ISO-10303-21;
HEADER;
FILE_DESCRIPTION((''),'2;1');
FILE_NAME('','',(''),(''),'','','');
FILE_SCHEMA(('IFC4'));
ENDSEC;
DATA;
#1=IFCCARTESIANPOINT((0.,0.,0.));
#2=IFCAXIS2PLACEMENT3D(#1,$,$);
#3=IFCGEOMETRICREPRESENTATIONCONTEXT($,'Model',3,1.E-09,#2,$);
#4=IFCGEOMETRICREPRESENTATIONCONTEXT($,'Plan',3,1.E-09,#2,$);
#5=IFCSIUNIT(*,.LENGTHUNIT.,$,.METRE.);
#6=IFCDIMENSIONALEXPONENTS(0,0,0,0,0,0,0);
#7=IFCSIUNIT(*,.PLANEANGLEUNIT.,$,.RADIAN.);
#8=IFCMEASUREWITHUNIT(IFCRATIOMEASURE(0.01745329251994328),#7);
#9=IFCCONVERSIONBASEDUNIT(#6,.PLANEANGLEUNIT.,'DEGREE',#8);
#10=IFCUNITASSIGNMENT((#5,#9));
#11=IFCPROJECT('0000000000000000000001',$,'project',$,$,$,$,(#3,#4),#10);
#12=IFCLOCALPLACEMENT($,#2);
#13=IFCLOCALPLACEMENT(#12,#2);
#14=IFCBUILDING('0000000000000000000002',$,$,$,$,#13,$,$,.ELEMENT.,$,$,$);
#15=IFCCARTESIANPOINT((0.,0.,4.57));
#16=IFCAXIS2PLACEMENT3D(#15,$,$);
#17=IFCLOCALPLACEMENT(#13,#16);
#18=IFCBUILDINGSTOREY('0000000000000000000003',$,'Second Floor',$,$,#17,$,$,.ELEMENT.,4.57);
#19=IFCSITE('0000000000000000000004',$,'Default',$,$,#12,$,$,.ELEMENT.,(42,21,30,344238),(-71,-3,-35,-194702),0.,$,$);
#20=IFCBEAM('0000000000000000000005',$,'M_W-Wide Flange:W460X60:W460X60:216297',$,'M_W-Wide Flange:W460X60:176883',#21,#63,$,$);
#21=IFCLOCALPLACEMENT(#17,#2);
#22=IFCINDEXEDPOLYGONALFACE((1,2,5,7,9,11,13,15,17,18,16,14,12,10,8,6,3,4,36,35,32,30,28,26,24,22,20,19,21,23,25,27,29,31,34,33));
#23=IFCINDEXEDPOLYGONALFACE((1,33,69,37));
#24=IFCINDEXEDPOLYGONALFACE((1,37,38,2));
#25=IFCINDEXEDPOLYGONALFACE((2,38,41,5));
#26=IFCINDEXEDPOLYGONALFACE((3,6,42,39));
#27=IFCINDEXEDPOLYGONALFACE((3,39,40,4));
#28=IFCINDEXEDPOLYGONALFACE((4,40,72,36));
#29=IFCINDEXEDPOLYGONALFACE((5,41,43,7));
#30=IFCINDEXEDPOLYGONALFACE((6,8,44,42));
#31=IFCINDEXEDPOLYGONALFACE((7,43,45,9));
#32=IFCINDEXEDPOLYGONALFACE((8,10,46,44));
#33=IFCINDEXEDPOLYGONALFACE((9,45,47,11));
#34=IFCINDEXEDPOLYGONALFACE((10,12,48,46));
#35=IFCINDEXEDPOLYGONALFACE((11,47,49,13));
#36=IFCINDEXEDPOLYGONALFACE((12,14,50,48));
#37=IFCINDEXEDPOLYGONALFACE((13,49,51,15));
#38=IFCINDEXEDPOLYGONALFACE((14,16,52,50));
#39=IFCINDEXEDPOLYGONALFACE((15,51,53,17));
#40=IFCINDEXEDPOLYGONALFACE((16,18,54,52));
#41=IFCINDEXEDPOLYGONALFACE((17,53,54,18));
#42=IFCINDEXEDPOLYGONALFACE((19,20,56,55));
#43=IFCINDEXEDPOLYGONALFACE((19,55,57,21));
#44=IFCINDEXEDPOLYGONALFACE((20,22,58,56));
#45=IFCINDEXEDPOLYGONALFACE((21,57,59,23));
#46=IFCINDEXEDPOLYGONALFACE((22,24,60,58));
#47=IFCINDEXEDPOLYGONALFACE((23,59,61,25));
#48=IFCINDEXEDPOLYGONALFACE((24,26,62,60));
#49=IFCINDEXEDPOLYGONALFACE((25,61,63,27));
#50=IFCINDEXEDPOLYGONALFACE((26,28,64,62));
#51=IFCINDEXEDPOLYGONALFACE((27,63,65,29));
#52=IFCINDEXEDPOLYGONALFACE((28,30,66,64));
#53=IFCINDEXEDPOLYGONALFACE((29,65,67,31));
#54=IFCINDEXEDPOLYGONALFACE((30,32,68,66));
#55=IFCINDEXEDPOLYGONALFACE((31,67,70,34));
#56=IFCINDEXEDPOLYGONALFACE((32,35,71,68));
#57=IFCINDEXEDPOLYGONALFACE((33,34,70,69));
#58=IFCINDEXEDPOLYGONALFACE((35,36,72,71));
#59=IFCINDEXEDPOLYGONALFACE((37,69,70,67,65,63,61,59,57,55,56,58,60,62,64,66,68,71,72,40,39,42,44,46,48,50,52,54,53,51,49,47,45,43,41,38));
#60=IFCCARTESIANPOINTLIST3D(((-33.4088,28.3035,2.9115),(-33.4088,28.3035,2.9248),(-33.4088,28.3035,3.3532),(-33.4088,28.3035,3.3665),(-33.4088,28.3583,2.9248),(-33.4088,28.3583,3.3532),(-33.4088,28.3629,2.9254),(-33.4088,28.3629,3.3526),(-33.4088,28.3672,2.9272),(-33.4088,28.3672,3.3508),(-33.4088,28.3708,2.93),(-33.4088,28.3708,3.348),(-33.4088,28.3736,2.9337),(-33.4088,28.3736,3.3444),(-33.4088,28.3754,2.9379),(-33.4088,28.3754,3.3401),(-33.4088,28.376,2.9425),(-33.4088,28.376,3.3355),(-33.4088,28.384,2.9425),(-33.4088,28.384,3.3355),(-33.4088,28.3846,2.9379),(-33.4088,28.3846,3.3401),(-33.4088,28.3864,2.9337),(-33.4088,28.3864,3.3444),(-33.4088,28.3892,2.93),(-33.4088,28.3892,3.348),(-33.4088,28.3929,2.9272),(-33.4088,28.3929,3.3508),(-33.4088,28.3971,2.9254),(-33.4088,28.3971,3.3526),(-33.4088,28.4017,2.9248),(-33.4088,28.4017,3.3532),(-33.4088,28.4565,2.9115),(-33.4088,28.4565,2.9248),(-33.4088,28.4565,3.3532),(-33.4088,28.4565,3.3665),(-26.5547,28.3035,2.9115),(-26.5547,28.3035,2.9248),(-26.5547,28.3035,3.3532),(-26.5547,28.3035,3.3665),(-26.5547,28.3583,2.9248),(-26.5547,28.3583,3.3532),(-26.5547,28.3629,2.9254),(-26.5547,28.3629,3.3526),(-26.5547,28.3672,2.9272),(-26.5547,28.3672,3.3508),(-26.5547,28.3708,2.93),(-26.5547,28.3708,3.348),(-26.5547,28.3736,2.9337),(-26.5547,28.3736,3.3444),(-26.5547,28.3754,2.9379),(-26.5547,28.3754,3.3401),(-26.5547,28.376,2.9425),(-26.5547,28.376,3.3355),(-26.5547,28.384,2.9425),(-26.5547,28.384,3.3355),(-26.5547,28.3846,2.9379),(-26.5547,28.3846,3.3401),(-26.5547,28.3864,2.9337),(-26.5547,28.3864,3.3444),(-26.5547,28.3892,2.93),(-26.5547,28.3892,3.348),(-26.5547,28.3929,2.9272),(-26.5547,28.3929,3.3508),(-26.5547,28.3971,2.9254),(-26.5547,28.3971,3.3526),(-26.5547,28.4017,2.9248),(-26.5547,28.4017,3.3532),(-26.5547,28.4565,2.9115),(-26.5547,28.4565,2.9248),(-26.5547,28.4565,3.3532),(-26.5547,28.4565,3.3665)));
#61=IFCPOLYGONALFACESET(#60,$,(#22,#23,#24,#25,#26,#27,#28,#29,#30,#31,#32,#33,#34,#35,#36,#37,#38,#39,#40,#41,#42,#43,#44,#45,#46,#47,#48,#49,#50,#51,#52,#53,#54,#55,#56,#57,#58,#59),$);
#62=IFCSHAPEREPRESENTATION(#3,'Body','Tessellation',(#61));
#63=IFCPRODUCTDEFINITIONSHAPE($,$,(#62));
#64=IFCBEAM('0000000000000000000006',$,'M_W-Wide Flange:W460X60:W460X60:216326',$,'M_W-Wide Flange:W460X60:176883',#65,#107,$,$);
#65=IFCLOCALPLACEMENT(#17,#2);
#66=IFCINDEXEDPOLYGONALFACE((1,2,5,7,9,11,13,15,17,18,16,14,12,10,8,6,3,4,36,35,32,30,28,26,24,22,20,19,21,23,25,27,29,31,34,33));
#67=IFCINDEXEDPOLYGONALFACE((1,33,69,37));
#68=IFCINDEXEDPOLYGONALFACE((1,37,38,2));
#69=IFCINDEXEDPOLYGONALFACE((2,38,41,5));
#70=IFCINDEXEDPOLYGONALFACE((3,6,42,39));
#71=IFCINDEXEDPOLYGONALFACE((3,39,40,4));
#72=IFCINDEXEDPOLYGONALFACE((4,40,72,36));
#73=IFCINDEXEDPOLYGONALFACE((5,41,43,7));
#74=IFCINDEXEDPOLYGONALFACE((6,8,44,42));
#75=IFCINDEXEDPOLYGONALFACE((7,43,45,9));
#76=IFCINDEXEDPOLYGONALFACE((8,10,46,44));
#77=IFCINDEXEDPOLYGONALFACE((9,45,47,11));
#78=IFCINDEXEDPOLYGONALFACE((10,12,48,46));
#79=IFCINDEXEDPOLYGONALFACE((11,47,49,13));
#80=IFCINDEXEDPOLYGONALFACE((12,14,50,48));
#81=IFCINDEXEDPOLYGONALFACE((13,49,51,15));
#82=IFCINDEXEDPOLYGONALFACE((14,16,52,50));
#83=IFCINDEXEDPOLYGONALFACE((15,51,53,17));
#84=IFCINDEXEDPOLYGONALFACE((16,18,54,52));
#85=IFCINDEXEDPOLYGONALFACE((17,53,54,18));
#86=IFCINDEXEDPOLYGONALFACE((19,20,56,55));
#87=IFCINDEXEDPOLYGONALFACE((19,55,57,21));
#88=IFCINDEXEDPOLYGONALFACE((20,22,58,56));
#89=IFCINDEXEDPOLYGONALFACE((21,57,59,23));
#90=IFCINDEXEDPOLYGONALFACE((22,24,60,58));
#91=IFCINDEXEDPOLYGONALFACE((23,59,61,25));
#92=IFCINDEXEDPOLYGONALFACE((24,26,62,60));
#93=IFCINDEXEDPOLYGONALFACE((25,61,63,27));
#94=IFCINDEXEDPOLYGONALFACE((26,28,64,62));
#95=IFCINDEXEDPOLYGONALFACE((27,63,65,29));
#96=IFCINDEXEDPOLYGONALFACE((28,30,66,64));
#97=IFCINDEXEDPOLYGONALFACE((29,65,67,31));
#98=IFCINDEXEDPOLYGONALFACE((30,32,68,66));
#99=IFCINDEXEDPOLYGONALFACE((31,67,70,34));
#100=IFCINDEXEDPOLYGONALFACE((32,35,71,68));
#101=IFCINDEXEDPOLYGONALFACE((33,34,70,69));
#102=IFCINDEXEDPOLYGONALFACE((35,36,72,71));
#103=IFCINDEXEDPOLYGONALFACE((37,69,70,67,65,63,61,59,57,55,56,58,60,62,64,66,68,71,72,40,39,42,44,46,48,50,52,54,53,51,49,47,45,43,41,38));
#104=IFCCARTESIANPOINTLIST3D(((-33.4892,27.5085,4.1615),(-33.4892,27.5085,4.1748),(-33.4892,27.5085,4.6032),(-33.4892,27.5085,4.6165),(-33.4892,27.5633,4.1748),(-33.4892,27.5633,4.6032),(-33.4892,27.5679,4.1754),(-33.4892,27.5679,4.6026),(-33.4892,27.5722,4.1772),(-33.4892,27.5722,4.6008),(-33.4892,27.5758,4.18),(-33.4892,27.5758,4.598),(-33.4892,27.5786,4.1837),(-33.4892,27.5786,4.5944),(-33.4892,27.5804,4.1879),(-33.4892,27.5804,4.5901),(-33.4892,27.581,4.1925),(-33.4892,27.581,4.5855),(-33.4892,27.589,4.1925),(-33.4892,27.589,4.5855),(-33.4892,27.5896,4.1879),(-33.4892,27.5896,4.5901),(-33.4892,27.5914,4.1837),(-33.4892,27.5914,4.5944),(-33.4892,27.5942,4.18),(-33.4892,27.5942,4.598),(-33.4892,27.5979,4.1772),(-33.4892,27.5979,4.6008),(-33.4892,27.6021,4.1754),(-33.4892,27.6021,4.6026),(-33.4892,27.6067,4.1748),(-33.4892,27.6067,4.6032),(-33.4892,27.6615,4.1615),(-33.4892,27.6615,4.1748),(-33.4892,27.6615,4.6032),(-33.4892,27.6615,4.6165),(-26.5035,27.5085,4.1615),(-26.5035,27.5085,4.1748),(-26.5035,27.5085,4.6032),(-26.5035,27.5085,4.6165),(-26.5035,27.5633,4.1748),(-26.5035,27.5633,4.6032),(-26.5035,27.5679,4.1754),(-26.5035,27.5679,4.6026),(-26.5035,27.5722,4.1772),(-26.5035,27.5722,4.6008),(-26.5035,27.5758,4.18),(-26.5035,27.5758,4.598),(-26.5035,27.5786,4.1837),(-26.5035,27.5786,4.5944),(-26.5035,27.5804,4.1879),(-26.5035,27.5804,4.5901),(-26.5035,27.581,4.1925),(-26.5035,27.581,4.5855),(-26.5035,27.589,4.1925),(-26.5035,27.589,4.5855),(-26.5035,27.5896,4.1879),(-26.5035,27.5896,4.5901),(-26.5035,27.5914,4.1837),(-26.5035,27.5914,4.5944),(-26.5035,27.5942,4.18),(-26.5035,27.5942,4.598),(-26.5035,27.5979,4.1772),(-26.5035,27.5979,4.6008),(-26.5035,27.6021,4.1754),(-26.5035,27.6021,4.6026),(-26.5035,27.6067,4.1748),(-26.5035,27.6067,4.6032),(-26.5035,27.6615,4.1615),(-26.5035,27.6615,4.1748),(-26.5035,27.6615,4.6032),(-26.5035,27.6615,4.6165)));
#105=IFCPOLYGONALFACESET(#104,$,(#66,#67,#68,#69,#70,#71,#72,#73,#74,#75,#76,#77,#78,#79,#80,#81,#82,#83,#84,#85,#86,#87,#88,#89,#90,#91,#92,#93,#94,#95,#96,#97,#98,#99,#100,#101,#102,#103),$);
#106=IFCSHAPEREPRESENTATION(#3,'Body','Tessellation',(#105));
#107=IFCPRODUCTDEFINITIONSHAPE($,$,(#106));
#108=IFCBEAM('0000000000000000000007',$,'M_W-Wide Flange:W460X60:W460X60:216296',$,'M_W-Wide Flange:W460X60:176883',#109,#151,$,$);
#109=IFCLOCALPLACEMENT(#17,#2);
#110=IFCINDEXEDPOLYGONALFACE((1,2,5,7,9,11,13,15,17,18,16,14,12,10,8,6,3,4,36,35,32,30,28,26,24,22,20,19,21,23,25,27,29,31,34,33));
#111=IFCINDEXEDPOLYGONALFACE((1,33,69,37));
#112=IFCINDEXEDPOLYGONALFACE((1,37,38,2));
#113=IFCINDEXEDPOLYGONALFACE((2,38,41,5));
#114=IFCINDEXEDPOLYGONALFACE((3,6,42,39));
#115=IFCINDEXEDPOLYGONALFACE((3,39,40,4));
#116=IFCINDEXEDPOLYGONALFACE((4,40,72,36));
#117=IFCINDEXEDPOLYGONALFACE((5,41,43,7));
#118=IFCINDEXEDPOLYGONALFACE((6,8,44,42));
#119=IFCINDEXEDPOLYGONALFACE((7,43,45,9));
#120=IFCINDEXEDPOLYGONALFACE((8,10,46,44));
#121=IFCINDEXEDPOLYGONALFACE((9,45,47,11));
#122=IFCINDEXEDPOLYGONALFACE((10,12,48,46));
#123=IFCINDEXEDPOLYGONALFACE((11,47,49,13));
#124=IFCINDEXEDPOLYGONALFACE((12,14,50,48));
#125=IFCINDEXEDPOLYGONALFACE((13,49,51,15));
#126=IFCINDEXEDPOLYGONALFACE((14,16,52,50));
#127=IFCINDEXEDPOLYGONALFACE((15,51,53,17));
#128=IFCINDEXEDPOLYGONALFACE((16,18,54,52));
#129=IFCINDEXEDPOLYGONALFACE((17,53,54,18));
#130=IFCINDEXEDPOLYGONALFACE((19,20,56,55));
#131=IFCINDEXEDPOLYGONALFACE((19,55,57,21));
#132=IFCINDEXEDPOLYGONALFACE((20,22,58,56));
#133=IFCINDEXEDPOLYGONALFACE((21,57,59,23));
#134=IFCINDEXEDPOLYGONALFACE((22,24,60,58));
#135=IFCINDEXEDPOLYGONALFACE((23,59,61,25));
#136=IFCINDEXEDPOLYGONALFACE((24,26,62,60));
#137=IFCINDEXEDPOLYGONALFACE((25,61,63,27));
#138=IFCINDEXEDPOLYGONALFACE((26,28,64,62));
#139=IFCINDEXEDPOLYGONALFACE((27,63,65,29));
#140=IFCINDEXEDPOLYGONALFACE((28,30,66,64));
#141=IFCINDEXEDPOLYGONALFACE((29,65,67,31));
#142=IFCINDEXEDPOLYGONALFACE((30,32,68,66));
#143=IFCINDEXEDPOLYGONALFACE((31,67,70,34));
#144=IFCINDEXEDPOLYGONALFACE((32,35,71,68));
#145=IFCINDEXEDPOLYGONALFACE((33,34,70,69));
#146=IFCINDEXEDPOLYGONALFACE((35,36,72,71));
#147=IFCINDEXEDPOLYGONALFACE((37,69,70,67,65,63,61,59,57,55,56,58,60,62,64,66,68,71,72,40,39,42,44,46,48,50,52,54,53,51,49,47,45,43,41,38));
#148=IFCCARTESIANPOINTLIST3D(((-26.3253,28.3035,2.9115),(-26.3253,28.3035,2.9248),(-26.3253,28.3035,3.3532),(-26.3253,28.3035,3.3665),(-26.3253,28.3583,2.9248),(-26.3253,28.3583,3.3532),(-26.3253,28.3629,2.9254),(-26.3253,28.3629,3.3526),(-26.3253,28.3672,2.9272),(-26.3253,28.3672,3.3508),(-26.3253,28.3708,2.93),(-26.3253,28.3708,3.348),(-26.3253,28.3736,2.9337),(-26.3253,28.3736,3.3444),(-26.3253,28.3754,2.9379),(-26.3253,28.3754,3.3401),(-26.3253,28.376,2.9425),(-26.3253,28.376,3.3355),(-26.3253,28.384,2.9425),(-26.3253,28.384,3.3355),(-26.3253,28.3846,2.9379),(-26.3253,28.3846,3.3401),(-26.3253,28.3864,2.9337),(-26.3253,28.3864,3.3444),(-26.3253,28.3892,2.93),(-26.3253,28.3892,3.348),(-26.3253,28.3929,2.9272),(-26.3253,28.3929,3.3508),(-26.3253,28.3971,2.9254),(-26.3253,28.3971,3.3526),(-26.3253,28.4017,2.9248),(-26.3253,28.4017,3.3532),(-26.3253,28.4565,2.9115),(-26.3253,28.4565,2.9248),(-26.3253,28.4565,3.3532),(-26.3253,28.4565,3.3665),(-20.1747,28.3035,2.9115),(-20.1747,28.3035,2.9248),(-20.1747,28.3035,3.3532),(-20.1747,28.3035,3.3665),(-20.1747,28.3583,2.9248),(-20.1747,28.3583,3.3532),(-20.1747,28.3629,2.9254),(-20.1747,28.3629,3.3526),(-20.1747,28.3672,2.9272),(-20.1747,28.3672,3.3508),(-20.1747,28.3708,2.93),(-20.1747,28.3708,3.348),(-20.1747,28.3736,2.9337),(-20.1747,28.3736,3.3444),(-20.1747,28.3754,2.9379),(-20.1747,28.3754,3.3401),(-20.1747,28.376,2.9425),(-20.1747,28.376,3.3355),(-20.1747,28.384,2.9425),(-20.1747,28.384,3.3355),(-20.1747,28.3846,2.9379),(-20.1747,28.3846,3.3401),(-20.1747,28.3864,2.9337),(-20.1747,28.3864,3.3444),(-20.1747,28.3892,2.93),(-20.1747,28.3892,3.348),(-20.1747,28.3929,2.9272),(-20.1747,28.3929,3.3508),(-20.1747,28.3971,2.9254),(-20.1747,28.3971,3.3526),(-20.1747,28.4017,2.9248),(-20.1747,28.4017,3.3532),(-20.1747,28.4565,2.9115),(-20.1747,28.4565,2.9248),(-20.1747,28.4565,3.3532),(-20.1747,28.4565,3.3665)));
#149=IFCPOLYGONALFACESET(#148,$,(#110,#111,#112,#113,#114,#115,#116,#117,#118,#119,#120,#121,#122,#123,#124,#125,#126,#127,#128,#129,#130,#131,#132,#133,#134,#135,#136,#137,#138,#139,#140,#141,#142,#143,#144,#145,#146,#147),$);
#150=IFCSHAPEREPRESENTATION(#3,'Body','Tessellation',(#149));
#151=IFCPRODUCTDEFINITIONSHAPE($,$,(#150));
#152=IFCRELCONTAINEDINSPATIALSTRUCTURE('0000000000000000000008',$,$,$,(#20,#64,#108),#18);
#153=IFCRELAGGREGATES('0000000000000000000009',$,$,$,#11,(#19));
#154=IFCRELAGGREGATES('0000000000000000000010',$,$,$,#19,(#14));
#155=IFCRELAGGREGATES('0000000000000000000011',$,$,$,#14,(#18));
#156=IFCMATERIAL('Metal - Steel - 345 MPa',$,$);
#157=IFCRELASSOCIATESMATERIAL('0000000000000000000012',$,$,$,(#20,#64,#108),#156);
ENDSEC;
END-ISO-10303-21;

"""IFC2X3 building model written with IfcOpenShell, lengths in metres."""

from ifc_helpers import new_model, entity, si_unit, converted_unit, frame, frame_2d, origin, place, context, project, spatial, polyline, circle_curve, parameter, trimmed, segment, composite_curve, outline, extrude, material, element, save


model = new_model("IFC2X3")

# Units and contexts
model_context = context("Model", 3, precision=1e-09, world=origin())
plan_context = context("Plan", 3, precision=1e-09, world=origin())
ifc_project = project(units=[si_unit("LENGTHUNIT", "METRE"), converted_unit("PLANEANGLEUNIT", "DEGREE", entity("IfcRatioMeasure", 0.01745329251994328), si_unit("PLANEANGLEUNIT", "RADIAN"), dimensions=[0, 0, 0, 0, 0, 0, 0])], contexts=[model_context, plan_context])

# Site, building, storey
site_placement = place(None, origin())
site = spatial("IfcSite", under=ifc_project, at=site_placement, Name="Default", CompositionType="ELEMENT", RefLatitude=(42, 21, 30, 344238), RefLongitude=(-71, -3, -35, -194702), RefElevation=0.0)
building_placement = place(site_placement, origin())
building = spatial("IfcBuilding", under=site, at=building_placement, CompositionType="ELEMENT")
storey_placement = place(building_placement, frame((0.0, 0.0, 4.57)))
storey = spatial("IfcBuildingStorey", under=building, at=storey_placement, Name="Second Floor", CompositionType="ELEMENT", Elevation=4.57)

# Shared definitions
ifc_material = material(Name="Metal - Steel - 345 MPa")

# Beams
beam_1_placement = place(storey_placement, frame((-26.5517, 28.38, 3.3665), z_axis=(0.0, 0.0, 1.0), x_axis=(0.0, 1.0, 0.0)))
element("IfcBeam", 1, at=beam_1_placement, inside=storey, material=ifc_material, Name="M_W-Wide Flange:W460X60:W460X60:216297", ObjectType="M_W-Wide Flange:W460X60:176883", context=model_context, shape_type="SweptSolid", body=[
    extrude(outline(composite_curve([segment(polyline([(-0.0765, -0.2142), (-0.0765, -0.2275)]), True, "CONTINUOUS"), segment(polyline([(-0.0765, -0.2275), (0.0765, -0.2275)]), True, "CONTINUOUS"), segment(polyline([(0.0765, -0.2275), (0.0765, -0.2142)]), True, "CONTINUOUS"), segment(polyline([(0.0765, -0.2142), (0.0217, -0.2142)]), True, "CONTINUOUS"), segment(trimmed(circle_curve(frame_2d((0.0217, -0.1965), x_axis=(1.0, 0.0)), 0.0177), [parameter(180.0)], [parameter(270.0)], True, "PARAMETER"), False, "CONTINUOUS"), segment(polyline([(0.004, -0.1965), (0.004, 0.1965)]), True, "CONTINUOUS"), segment(trimmed(circle_curve(frame_2d((0.0217, 0.1965), x_axis=(1.0, 0.0)), 0.0177), [parameter(90.0)], [parameter(180.0)], True, "PARAMETER"), False, "CONTINUOUS"), segment(polyline([(0.0217, 0.2142), (0.0765, 0.2142)]), True, "CONTINUOUS"), segment(polyline([(0.0765, 0.2142), (0.0765, 0.2275)]), True, "CONTINUOUS"), segment(polyline([(0.0765, 0.2275), (-0.0765, 0.2275)]), True, "CONTINUOUS"), segment(polyline([(-0.0765, 0.2275), (-0.0765, 0.2142)]), True, "CONTINUOUS"), segment(polyline([(-0.0765, 0.2142), (-0.0217, 0.2142)]), True, "CONTINUOUS"), segment(trimmed(circle_curve(frame_2d((-0.0217, 0.1965), x_axis=(1.0, 0.0)), 0.0177), [parameter(360.0)], [parameter(90.0)], True, "PARAMETER"), False, "CONTINUOUS"), segment(polyline([(-0.004, 0.1965), (-0.004, -0.1965)]), True, "CONTINUOUS"), segment(trimmed(circle_curve(frame_2d((-0.0217, -0.1965), x_axis=(1.0, 0.0)), 0.0177), [parameter(270.0)], [parameter(0.0)], True, "PARAMETER"), False, "CONTINUOUS"), segment(polyline([(-0.0217, -0.2142), (-0.0765, -0.2142)]), True, "CONTINUOUS")], self_intersect=False)), frame((0.0, 6.8571, -0.2275), z_axis=(0.0, 1.0, 0.0), x_axis=(-1.0, 0.0, 0.0)), (0.0, 0.0, -1.0), 6.8541),
])
beam_2_placement = place(storey_placement, frame((-26.4403, 27.585, 4.6165), z_axis=(0.0, 0.0, 1.0), x_axis=(0.0, 1.0, 0.0)))
element("IfcBeam", 2, at=beam_2_placement, inside=storey, material=ifc_material, Name="M_W-Wide Flange:W460X60:W460X60:216326", ObjectType="M_W-Wide Flange:W460X60:176883", context=model_context, shape_type="SweptSolid", body=[
    extrude(outline(composite_curve([segment(polyline([(-0.0765, -0.2142), (-0.0765, -0.2275)]), True, "CONTINUOUS"), segment(polyline([(-0.0765, -0.2275), (0.0765, -0.2275)]), True, "CONTINUOUS"), segment(polyline([(0.0765, -0.2275), (0.0765, -0.2142)]), True, "CONTINUOUS"), segment(polyline([(0.0765, -0.2142), (0.0217, -0.2142)]), True, "CONTINUOUS"), segment(trimmed(circle_curve(frame_2d((0.0217, -0.1965), x_axis=(1.0, 0.0)), 0.0177), [parameter(180.0)], [parameter(270.0)], True, "PARAMETER"), False, "CONTINUOUS"), segment(polyline([(0.004, -0.1965), (0.004, 0.1965)]), True, "CONTINUOUS"), segment(trimmed(circle_curve(frame_2d((0.0217, 0.1965), x_axis=(1.0, 0.0)), 0.0177), [parameter(90.0)], [parameter(180.0)], True, "PARAMETER"), False, "CONTINUOUS"), segment(polyline([(0.0217, 0.2142), (0.0765, 0.2142)]), True, "CONTINUOUS"), segment(polyline([(0.0765, 0.2142), (0.0765, 0.2275)]), True, "CONTINUOUS"), segment(polyline([(0.0765, 0.2275), (-0.0765, 0.2275)]), True, "CONTINUOUS"), segment(polyline([(-0.0765, 0.2275), (-0.0765, 0.2142)]), True, "CONTINUOUS"), segment(polyline([(-0.0765, 0.2142), (-0.0217, 0.2142)]), True, "CONTINUOUS"), segment(trimmed(circle_curve(frame_2d((-0.0217, 0.1965), x_axis=(1.0, 0.0)), 0.0177), [parameter(360.0)], [parameter(90.0)], True, "PARAMETER"), False, "CONTINUOUS"), segment(polyline([(-0.004, 0.1965), (-0.004, -0.1965)]), True, "CONTINUOUS"), segment(trimmed(circle_curve(frame_2d((-0.0217, -0.1965), x_axis=(1.0, 0.0)), 0.0177), [parameter(270.0)], [parameter(0.0)], True, "PARAMETER"), False, "CONTINUOUS"), segment(polyline([(-0.0217, -0.2142), (-0.0765, -0.2142)]), True, "CONTINUOUS")], self_intersect=False)), frame((0.0, 7.0489, -0.2275), z_axis=(0.0, 1.0, 0.0), x_axis=(-1.0, 0.0, 0.0)), (0.0, 0.0, -1.0), 6.9857),
])
beam_3_placement = place(storey_placement, frame((-20.1843, 28.38, 3.3665), z_axis=(0.0, 0.0, 1.0), x_axis=(0.0, 1.0, 0.0)))
element("IfcBeam", 3, at=beam_3_placement, inside=storey, material=ifc_material, Name="M_W-Wide Flange:W460X60:W460X60:216296", ObjectType="M_W-Wide Flange:W460X60:176883", context=model_context, shape_type="SweptSolid", body=[
    extrude(outline(composite_curve([segment(polyline([(-0.0765, -0.2142), (-0.0765, -0.2275)]), True, "CONTINUOUS"), segment(polyline([(-0.0765, -0.2275), (0.0765, -0.2275)]), True, "CONTINUOUS"), segment(polyline([(0.0765, -0.2275), (0.0765, -0.2142)]), True, "CONTINUOUS"), segment(polyline([(0.0765, -0.2142), (0.0217, -0.2142)]), True, "CONTINUOUS"), segment(trimmed(circle_curve(frame_2d((0.0217, -0.1965), x_axis=(1.0, 0.0)), 0.0177), [parameter(180.0)], [parameter(270.0)], True, "PARAMETER"), False, "CONTINUOUS"), segment(polyline([(0.004, -0.1965), (0.004, 0.1965)]), True, "CONTINUOUS"), segment(trimmed(circle_curve(frame_2d((0.0217, 0.1965), x_axis=(1.0, 0.0)), 0.0177), [parameter(90.0)], [parameter(180.0)], True, "PARAMETER"), False, "CONTINUOUS"), segment(polyline([(0.0217, 0.2142), (0.0765, 0.2142)]), True, "CONTINUOUS"), segment(polyline([(0.0765, 0.2142), (0.0765, 0.2275)]), True, "CONTINUOUS"), segment(polyline([(0.0765, 0.2275), (-0.0765, 0.2275)]), True, "CONTINUOUS"), segment(polyline([(-0.0765, 0.2275), (-0.0765, 0.2142)]), True, "CONTINUOUS"), segment(polyline([(-0.0765, 0.2142), (-0.0217, 0.2142)]), True, "CONTINUOUS"), segment(trimmed(circle_curve(frame_2d((-0.0217, 0.1965), x_axis=(1.0, 0.0)), 0.0177), [parameter(360.0)], [parameter(90.0)], True, "PARAMETER"), False, "CONTINUOUS"), segment(polyline([(-0.004, 0.1965), (-0.004, -0.1965)]), True, "CONTINUOUS"), segment(trimmed(circle_curve(frame_2d((-0.0217, -0.1965), x_axis=(1.0, 0.0)), 0.0177), [parameter(270.0)], [parameter(0.0)], True, "PARAMETER"), False, "CONTINUOUS"), segment(polyline([(-0.0217, -0.2142), (-0.0765, -0.2142)]), True, "CONTINUOUS")], self_intersect=False)), frame((0.0, 6.141, -0.2275), z_axis=(0.0, 1.0, 0.0), x_axis=(-1.0, 0.0, 0.0)), (0.0, 0.0, -1.0), 6.1506),
])

save(model, "model.ifc")
